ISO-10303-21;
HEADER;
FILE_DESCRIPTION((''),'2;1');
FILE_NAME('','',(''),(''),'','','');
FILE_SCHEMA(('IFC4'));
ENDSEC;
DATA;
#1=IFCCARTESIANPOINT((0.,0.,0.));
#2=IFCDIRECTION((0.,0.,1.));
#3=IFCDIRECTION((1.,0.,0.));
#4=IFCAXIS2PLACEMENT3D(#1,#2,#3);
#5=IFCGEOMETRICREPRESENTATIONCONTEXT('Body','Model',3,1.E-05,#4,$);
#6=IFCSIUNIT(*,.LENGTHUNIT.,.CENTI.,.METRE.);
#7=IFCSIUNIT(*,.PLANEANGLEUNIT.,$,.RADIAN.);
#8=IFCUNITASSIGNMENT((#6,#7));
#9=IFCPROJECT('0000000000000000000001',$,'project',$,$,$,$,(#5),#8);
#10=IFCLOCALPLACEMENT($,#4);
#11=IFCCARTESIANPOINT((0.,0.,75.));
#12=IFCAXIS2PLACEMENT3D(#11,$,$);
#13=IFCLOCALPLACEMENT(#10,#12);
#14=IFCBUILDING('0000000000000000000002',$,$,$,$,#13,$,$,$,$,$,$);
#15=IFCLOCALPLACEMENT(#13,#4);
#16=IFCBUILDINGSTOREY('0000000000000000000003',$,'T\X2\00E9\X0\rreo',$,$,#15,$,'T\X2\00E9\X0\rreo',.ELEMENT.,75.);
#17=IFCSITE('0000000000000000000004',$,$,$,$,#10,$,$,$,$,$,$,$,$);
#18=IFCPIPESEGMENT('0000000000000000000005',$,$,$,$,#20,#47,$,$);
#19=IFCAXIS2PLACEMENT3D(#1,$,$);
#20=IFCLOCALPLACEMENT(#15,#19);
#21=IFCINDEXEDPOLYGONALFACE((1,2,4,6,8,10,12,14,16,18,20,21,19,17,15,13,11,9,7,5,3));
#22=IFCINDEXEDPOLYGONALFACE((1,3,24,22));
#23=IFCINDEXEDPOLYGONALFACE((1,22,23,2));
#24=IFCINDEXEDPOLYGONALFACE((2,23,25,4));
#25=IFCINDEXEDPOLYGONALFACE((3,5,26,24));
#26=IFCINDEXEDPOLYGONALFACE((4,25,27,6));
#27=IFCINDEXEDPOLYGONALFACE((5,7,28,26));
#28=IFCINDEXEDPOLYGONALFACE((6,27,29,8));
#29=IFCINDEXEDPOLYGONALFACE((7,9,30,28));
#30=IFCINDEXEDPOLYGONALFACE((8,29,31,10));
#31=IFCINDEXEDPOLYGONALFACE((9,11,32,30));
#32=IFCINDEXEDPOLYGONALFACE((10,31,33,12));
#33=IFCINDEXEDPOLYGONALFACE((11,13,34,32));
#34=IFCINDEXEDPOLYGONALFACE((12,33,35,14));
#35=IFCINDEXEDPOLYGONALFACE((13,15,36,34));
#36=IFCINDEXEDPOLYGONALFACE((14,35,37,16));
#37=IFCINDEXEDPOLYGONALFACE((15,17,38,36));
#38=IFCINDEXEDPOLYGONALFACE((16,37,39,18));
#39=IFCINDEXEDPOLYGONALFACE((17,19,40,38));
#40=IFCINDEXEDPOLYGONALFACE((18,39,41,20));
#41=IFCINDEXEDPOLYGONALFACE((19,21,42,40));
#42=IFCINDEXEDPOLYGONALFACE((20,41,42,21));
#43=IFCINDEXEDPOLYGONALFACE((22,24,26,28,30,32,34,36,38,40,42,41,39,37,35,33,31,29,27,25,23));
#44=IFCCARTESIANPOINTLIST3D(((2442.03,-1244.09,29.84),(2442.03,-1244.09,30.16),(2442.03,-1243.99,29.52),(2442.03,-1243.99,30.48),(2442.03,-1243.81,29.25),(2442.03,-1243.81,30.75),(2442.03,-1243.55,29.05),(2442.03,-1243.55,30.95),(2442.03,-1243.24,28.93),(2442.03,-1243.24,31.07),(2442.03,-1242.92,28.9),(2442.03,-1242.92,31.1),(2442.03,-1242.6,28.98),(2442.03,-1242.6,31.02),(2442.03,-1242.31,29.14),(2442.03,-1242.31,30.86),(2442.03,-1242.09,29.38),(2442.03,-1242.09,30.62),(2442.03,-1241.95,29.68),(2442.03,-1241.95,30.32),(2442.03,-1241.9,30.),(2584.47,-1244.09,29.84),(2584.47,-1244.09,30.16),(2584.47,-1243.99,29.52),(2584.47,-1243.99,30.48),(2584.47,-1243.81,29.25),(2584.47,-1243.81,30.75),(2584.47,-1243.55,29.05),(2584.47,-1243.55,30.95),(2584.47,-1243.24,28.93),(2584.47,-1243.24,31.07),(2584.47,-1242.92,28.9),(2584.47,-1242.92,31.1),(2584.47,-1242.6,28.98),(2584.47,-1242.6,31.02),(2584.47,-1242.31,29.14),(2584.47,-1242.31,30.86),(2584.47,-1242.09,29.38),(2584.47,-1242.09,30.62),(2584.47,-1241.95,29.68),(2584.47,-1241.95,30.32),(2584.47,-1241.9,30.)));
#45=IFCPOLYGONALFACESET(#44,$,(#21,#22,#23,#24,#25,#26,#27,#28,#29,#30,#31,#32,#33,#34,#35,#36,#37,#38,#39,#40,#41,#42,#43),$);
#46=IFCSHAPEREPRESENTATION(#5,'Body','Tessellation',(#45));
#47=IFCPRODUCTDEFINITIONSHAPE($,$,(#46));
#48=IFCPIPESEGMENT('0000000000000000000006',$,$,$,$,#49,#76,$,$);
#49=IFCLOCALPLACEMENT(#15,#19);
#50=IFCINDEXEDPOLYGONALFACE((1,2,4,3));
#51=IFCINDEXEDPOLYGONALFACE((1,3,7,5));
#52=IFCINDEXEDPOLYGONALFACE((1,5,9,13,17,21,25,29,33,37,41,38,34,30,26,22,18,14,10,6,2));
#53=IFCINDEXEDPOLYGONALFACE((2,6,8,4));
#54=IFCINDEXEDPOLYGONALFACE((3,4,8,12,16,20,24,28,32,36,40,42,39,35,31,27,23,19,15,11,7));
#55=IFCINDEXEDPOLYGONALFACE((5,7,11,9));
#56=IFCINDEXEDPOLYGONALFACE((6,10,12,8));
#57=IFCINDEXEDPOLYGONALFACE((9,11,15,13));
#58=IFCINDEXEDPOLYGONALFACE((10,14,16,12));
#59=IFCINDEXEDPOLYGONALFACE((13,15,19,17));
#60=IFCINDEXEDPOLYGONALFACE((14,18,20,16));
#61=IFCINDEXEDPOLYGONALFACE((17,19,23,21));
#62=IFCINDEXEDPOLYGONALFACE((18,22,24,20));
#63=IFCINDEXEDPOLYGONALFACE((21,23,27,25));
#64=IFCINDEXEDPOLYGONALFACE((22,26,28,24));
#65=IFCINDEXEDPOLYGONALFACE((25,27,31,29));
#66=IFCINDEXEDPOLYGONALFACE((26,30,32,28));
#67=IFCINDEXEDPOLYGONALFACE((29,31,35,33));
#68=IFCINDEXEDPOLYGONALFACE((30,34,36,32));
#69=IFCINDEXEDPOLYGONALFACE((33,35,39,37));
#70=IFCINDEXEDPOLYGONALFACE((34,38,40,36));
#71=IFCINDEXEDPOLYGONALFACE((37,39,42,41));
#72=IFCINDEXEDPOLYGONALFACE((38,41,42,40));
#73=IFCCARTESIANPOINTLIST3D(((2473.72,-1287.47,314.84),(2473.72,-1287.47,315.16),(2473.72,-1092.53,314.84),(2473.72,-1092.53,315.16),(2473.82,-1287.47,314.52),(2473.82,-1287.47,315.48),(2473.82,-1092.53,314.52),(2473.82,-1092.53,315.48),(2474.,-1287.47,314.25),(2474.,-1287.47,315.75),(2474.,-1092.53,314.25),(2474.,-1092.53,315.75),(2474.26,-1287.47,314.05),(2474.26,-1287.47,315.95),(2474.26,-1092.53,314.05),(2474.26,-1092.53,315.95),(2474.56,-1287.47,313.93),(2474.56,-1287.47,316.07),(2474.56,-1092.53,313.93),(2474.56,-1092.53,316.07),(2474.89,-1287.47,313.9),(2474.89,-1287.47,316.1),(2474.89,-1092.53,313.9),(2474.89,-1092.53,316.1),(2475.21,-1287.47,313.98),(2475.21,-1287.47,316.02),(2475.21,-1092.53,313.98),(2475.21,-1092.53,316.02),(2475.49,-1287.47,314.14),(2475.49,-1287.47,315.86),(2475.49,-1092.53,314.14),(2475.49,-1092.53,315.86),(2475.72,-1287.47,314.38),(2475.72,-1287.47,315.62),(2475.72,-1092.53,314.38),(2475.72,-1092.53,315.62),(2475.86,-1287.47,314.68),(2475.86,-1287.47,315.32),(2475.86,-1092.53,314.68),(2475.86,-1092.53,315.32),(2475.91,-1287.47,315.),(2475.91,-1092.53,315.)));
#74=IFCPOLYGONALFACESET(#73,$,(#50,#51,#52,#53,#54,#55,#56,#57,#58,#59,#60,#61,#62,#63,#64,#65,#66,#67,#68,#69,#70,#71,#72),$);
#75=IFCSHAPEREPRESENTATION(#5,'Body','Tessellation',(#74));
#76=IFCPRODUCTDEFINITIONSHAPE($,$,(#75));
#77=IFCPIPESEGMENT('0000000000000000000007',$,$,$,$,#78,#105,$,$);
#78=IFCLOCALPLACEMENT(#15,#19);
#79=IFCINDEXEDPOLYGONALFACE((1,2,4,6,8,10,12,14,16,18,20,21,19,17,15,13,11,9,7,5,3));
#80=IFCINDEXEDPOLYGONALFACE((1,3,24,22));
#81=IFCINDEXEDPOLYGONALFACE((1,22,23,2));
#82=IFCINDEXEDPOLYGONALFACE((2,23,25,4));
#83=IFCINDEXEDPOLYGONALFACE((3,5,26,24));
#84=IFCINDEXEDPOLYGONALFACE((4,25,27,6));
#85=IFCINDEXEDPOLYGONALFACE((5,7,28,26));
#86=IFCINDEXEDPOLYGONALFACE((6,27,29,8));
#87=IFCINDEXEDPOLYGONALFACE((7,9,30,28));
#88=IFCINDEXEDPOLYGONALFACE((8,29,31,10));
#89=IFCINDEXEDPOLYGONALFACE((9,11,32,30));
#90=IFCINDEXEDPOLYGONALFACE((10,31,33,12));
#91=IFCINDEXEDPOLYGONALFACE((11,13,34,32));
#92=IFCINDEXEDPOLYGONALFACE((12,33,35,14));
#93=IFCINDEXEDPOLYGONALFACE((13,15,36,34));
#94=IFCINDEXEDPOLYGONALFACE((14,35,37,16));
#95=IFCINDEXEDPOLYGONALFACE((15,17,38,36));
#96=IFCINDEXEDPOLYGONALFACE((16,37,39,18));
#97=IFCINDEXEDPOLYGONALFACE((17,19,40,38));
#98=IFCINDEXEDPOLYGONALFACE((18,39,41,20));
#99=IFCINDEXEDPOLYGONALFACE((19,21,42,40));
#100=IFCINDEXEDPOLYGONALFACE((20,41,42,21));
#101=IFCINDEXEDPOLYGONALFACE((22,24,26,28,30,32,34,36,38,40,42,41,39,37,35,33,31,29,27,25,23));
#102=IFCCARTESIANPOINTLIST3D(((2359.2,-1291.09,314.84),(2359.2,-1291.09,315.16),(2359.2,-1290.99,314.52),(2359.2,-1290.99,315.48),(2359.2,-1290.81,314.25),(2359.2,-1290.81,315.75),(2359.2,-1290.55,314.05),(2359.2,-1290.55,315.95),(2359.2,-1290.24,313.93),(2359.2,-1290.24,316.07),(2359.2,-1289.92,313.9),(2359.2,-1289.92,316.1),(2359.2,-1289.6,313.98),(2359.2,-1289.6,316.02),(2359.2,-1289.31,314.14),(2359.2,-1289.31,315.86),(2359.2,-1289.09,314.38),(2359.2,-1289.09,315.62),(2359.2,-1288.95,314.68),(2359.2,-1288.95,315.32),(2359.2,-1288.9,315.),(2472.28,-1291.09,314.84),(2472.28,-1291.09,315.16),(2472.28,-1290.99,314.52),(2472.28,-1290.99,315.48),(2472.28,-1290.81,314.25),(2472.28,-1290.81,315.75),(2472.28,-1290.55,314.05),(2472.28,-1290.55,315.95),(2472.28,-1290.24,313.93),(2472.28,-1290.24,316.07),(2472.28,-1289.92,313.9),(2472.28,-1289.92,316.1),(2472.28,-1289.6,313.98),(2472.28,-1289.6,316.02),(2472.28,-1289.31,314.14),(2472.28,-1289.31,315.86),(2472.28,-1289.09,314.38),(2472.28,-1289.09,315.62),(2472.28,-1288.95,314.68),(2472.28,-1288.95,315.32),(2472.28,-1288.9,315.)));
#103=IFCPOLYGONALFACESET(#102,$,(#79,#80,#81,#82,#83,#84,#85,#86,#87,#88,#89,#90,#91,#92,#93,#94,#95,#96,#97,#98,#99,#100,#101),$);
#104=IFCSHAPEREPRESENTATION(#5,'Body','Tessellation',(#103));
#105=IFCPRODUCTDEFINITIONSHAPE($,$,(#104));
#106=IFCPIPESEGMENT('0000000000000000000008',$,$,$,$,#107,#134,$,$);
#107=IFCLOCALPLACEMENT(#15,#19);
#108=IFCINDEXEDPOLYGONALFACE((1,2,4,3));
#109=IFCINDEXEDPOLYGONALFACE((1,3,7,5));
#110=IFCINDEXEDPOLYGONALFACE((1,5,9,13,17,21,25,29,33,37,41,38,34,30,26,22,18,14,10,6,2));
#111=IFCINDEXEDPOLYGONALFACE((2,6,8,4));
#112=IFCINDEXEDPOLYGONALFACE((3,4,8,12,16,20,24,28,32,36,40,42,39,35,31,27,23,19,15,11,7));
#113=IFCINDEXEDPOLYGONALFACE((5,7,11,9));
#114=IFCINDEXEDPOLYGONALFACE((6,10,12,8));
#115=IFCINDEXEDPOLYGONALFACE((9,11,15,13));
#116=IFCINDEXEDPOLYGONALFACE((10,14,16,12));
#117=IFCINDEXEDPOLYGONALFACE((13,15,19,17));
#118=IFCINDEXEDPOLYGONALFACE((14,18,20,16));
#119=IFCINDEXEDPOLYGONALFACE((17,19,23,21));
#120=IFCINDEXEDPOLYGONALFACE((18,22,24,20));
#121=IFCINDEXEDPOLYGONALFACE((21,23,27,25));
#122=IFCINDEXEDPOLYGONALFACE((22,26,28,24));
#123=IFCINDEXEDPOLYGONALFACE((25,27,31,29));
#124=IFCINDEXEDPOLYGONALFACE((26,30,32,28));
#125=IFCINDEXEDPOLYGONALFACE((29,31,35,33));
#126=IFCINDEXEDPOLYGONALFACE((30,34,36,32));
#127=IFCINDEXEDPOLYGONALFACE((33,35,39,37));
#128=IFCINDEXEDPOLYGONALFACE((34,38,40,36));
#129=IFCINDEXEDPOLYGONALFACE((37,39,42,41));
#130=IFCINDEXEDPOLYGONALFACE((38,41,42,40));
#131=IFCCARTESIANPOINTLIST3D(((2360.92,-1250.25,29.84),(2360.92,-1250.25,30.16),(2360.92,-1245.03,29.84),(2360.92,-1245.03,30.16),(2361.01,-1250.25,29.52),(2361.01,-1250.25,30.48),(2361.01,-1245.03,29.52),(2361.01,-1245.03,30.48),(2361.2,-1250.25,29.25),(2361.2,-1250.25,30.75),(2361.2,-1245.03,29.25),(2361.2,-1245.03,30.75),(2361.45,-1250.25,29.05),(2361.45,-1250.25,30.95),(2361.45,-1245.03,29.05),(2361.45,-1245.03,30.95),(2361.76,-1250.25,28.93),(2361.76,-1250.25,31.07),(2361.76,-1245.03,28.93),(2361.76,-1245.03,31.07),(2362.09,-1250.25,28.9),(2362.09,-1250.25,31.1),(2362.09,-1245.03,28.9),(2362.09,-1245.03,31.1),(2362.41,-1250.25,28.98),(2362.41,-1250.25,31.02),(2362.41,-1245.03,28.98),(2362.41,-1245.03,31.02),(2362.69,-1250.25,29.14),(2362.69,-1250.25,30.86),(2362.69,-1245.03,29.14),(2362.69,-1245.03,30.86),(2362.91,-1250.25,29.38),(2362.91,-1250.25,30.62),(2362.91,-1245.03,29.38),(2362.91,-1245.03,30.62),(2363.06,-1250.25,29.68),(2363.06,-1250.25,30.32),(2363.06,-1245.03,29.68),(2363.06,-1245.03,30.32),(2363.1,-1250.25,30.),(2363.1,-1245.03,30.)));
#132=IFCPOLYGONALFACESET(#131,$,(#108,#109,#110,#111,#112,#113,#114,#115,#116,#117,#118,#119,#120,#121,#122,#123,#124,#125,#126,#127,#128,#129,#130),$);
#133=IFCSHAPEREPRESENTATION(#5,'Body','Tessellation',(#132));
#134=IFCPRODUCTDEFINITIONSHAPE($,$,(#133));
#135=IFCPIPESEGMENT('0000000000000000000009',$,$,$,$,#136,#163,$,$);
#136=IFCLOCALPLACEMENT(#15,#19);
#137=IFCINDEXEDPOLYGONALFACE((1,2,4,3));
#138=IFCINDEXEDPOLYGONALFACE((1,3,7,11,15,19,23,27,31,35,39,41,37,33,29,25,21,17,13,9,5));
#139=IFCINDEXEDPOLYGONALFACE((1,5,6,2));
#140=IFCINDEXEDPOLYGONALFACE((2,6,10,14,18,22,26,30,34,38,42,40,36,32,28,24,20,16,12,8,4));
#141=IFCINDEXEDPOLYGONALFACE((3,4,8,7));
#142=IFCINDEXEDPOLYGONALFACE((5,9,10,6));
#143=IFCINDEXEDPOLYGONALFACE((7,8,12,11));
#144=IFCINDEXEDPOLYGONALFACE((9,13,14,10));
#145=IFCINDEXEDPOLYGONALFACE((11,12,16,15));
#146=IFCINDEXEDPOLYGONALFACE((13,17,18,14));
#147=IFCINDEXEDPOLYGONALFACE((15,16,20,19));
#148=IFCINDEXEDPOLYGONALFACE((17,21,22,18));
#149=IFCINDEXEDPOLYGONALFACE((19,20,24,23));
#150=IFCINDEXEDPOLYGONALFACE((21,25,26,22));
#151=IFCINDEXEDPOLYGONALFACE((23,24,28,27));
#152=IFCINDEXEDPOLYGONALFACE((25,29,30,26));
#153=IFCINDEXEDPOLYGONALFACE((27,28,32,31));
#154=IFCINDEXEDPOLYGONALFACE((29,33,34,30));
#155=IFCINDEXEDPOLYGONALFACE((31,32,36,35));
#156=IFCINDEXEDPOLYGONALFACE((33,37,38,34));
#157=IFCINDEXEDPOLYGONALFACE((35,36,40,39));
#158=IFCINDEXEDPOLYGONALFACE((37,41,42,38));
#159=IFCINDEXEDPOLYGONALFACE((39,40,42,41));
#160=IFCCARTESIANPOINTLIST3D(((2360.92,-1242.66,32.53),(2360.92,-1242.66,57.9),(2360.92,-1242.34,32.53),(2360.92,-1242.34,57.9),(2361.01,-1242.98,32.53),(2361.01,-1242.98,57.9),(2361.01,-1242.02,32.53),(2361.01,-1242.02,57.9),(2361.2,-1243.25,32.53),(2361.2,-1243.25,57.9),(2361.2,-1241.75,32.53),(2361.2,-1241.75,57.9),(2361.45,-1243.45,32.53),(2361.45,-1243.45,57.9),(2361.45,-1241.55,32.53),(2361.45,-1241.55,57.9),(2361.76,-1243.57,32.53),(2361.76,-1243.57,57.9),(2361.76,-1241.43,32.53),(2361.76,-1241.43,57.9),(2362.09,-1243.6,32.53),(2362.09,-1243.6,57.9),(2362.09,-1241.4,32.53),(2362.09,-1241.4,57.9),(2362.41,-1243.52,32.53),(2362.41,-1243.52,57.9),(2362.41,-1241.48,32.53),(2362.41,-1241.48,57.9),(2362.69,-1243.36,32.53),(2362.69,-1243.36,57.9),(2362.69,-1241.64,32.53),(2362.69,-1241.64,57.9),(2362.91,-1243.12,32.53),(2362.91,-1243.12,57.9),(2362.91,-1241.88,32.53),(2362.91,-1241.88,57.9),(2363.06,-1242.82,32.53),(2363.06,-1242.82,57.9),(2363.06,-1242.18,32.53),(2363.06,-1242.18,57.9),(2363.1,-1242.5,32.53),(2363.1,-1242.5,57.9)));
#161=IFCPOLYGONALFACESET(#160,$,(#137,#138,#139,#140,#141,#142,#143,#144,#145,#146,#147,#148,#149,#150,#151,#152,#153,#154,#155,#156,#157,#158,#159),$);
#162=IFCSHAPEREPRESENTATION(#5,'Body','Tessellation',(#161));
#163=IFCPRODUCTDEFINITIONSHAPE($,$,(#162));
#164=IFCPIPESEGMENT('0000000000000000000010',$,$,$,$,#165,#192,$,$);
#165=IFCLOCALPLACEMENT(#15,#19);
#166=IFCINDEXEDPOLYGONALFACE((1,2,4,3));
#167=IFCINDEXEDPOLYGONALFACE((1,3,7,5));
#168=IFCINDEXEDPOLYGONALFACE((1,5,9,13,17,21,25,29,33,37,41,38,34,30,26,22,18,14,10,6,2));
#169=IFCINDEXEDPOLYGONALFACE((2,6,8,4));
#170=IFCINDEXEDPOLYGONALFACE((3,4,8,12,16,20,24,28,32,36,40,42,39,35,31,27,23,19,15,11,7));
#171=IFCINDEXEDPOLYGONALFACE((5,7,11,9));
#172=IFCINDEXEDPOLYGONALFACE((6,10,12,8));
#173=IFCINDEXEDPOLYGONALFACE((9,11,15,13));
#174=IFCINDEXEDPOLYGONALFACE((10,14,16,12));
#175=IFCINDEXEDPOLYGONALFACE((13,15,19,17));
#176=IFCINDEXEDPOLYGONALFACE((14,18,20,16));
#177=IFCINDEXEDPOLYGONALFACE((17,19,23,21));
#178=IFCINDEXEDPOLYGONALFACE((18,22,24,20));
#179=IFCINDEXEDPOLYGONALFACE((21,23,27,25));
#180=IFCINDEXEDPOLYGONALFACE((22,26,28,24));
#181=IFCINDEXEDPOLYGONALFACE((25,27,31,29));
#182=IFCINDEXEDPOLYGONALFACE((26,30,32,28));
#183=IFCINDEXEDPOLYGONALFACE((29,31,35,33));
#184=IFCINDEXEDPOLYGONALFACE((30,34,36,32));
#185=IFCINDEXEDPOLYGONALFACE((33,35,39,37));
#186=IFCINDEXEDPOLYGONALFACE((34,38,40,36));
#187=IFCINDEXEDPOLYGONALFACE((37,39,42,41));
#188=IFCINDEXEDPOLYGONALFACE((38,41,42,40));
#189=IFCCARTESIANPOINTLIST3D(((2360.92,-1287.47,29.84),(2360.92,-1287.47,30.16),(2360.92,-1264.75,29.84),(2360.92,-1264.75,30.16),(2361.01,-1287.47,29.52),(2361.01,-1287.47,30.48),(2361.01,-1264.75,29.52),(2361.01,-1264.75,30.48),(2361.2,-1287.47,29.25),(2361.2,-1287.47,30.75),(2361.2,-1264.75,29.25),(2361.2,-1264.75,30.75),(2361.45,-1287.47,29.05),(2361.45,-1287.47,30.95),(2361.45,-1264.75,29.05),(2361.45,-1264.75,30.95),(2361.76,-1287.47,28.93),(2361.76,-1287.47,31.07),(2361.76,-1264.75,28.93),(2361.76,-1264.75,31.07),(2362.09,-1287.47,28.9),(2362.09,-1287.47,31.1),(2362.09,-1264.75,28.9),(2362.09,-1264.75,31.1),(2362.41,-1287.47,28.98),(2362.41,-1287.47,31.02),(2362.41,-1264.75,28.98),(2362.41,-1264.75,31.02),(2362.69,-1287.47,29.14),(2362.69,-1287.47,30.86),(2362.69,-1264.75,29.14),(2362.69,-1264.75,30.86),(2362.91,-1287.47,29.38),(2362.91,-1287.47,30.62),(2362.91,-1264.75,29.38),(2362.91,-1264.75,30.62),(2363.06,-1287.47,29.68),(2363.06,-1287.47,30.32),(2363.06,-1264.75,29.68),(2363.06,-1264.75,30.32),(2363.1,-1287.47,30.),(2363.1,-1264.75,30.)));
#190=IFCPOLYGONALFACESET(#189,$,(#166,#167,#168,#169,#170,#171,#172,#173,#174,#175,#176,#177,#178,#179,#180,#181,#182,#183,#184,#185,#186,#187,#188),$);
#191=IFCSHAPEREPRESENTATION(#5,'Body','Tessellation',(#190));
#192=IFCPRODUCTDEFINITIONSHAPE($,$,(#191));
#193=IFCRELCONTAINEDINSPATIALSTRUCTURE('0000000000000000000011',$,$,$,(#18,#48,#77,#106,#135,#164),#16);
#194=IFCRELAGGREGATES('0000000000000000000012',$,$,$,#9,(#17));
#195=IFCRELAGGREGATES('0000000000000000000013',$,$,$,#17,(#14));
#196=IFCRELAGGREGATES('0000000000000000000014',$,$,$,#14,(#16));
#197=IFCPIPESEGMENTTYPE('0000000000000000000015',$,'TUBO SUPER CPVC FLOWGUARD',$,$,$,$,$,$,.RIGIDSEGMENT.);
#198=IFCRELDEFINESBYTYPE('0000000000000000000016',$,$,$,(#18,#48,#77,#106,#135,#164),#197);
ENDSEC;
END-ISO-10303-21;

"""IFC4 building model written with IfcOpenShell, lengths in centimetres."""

from ifc_helpers import new_model, si_unit, frame, origin_with_axes, origin_2d_with_axis, place, context, project, spatial, circle, extrude, type_object, element, save


model = new_model("IFC4")

# Units and contexts
model_context = context("Model", 3, precision=1e-05, world=origin_with_axes(), identifier="Body")
ifc_project = project(units=[si_unit("LENGTHUNIT", "METRE", prefix="CENTI"), si_unit("PLANEANGLEUNIT", "RADIAN")], contexts=[model_context])

# Site, building, storey
site_placement = place(None, origin_with_axes())
site = spatial("IfcSite", under=ifc_project, at=site_placement)
building_placement = place(site_placement, frame((0.0, 0.0, 75.0)))
building = spatial("IfcBuilding", under=site, at=building_placement)
storey_placement = place(building_placement, origin_with_axes())
storey = spatial("IfcBuildingStorey", under=building, at=storey_placement, Name="Térreo", LongName="Térreo", CompositionType="ELEMENT", Elevation=75.0)

# Pipe segments
pipe_segment_type_1 = type_object("IfcPipeSegmentType", Name="TUBO SUPER CPVC FLOWGUARD", PredefinedType="RIGIDSEGMENT")
pipe_segment_1_placement = place(storey_placement, frame((2513.25, -1243.0, 31.1), z_axis=(0.0, 0.0, 1.0), x_axis=(1.0, 0.0, 0.0)))
element("IfcPipeSegment", 1, at=pipe_segment_1_placement, inside=storey, type_object=pipe_segment_type_1, context=model_context, shape_type="SolidModel", body=[
    extrude(circle(Radius=1.1, at=origin_2d_with_axis()), frame((71.22, 0.0, -1.1), z_axis=(-1.0, 0.0, 0.0), x_axis=(0.0, 1.0, 0.0)), (0.0, 0.0, 1.0), 142.44),
])
pipe_segment_2_placement = place(storey_placement, frame((2474.81, -1190.0, 316.1), z_axis=(0.0, 0.0, 1.0), x_axis=(1.0, 0.0, 0.0)))
element("IfcPipeSegment", 2, at=pipe_segment_2_placement, inside=storey, type_object=pipe_segment_type_1, context=model_context, shape_type="SolidModel", body=[
    extrude(circle(Radius=1.1, at=origin_2d_with_axis()), frame((0.0, -97.47, -1.1), z_axis=(0.0, 1.0, 0.0), x_axis=(1.0, 0.0, 0.0)), (0.0, 0.0, 1.0), 194.94),
])
pipe_segment_3_placement = place(storey_placement, frame((2415.74, -1290.0, 316.1), z_axis=(0.0, 0.0, 1.0), x_axis=(1.0, 0.0, 0.0)))
element("IfcPipeSegment", 3, at=pipe_segment_3_placement, inside=storey, type_object=pipe_segment_type_1, context=model_context, shape_type="SolidModel", body=[
    extrude(circle(Radius=1.1, at=origin_2d_with_axis()), frame((-56.54, 0.0, -1.1), z_axis=(1.0, 0.0, 0.0), x_axis=(0.0, 1.0, 0.0)), (0.0, 0.0, 1.0), 113.07),
])
pipe_segment_4_placement = place(storey_placement, frame((2362.0, -1247.64, 31.1), z_axis=(0.0, 0.0, 1.0), x_axis=(1.0, 0.0, 0.0)))
element("IfcPipeSegment", 4, at=pipe_segment_4_placement, inside=storey, type_object=pipe_segment_type_1, context=model_context, shape_type="SolidModel", body=[
    extrude(circle(Radius=1.1, at=origin_2d_with_axis()), frame((0.0, -2.61, -1.1), z_axis=(0.0, 1.0, 0.0), x_axis=(1.0, 0.0, 0.0)), (0.0, 0.0, 1.0), 5.22),
])
pipe_segment_5_placement = place(storey_placement, frame((2362.0, -1242.5, 57.9), z_axis=(0.0, 0.0, 1.0), x_axis=(1.0, 0.0, 0.0)))
element("IfcPipeSegment", 5, at=pipe_segment_5_placement, inside=storey, type_object=pipe_segment_type_1, context=model_context, shape_type="SolidModel", body=[
    extrude(circle(Radius=1.1, at=origin_2d_with_axis()), frame((0.0, 0.0, -25.37), z_axis=(0.0, 0.0, 1.0), x_axis=(1.0, 0.0, 0.0)), (0.0, 0.0, 1.0), 25.37),
])
pipe_segment_6_placement = place(storey_placement, frame((2362.0, -1276.11, 31.1), z_axis=(0.0, 0.0, 1.0), x_axis=(1.0, 0.0, 0.0)))
element("IfcPipeSegment", 6, at=pipe_segment_6_placement, inside=storey, type_object=pipe_segment_type_1, context=model_context, shape_type="SolidModel", body=[
    extrude(circle(Radius=1.1, at=origin_2d_with_axis()), frame((0.0, -11.36, -1.1), z_axis=(0.0, 1.0, 0.0), x_axis=(1.0, 0.0, 0.0)), (0.0, 0.0, 1.0), 22.72),
])

save(model, "model.ifc")
